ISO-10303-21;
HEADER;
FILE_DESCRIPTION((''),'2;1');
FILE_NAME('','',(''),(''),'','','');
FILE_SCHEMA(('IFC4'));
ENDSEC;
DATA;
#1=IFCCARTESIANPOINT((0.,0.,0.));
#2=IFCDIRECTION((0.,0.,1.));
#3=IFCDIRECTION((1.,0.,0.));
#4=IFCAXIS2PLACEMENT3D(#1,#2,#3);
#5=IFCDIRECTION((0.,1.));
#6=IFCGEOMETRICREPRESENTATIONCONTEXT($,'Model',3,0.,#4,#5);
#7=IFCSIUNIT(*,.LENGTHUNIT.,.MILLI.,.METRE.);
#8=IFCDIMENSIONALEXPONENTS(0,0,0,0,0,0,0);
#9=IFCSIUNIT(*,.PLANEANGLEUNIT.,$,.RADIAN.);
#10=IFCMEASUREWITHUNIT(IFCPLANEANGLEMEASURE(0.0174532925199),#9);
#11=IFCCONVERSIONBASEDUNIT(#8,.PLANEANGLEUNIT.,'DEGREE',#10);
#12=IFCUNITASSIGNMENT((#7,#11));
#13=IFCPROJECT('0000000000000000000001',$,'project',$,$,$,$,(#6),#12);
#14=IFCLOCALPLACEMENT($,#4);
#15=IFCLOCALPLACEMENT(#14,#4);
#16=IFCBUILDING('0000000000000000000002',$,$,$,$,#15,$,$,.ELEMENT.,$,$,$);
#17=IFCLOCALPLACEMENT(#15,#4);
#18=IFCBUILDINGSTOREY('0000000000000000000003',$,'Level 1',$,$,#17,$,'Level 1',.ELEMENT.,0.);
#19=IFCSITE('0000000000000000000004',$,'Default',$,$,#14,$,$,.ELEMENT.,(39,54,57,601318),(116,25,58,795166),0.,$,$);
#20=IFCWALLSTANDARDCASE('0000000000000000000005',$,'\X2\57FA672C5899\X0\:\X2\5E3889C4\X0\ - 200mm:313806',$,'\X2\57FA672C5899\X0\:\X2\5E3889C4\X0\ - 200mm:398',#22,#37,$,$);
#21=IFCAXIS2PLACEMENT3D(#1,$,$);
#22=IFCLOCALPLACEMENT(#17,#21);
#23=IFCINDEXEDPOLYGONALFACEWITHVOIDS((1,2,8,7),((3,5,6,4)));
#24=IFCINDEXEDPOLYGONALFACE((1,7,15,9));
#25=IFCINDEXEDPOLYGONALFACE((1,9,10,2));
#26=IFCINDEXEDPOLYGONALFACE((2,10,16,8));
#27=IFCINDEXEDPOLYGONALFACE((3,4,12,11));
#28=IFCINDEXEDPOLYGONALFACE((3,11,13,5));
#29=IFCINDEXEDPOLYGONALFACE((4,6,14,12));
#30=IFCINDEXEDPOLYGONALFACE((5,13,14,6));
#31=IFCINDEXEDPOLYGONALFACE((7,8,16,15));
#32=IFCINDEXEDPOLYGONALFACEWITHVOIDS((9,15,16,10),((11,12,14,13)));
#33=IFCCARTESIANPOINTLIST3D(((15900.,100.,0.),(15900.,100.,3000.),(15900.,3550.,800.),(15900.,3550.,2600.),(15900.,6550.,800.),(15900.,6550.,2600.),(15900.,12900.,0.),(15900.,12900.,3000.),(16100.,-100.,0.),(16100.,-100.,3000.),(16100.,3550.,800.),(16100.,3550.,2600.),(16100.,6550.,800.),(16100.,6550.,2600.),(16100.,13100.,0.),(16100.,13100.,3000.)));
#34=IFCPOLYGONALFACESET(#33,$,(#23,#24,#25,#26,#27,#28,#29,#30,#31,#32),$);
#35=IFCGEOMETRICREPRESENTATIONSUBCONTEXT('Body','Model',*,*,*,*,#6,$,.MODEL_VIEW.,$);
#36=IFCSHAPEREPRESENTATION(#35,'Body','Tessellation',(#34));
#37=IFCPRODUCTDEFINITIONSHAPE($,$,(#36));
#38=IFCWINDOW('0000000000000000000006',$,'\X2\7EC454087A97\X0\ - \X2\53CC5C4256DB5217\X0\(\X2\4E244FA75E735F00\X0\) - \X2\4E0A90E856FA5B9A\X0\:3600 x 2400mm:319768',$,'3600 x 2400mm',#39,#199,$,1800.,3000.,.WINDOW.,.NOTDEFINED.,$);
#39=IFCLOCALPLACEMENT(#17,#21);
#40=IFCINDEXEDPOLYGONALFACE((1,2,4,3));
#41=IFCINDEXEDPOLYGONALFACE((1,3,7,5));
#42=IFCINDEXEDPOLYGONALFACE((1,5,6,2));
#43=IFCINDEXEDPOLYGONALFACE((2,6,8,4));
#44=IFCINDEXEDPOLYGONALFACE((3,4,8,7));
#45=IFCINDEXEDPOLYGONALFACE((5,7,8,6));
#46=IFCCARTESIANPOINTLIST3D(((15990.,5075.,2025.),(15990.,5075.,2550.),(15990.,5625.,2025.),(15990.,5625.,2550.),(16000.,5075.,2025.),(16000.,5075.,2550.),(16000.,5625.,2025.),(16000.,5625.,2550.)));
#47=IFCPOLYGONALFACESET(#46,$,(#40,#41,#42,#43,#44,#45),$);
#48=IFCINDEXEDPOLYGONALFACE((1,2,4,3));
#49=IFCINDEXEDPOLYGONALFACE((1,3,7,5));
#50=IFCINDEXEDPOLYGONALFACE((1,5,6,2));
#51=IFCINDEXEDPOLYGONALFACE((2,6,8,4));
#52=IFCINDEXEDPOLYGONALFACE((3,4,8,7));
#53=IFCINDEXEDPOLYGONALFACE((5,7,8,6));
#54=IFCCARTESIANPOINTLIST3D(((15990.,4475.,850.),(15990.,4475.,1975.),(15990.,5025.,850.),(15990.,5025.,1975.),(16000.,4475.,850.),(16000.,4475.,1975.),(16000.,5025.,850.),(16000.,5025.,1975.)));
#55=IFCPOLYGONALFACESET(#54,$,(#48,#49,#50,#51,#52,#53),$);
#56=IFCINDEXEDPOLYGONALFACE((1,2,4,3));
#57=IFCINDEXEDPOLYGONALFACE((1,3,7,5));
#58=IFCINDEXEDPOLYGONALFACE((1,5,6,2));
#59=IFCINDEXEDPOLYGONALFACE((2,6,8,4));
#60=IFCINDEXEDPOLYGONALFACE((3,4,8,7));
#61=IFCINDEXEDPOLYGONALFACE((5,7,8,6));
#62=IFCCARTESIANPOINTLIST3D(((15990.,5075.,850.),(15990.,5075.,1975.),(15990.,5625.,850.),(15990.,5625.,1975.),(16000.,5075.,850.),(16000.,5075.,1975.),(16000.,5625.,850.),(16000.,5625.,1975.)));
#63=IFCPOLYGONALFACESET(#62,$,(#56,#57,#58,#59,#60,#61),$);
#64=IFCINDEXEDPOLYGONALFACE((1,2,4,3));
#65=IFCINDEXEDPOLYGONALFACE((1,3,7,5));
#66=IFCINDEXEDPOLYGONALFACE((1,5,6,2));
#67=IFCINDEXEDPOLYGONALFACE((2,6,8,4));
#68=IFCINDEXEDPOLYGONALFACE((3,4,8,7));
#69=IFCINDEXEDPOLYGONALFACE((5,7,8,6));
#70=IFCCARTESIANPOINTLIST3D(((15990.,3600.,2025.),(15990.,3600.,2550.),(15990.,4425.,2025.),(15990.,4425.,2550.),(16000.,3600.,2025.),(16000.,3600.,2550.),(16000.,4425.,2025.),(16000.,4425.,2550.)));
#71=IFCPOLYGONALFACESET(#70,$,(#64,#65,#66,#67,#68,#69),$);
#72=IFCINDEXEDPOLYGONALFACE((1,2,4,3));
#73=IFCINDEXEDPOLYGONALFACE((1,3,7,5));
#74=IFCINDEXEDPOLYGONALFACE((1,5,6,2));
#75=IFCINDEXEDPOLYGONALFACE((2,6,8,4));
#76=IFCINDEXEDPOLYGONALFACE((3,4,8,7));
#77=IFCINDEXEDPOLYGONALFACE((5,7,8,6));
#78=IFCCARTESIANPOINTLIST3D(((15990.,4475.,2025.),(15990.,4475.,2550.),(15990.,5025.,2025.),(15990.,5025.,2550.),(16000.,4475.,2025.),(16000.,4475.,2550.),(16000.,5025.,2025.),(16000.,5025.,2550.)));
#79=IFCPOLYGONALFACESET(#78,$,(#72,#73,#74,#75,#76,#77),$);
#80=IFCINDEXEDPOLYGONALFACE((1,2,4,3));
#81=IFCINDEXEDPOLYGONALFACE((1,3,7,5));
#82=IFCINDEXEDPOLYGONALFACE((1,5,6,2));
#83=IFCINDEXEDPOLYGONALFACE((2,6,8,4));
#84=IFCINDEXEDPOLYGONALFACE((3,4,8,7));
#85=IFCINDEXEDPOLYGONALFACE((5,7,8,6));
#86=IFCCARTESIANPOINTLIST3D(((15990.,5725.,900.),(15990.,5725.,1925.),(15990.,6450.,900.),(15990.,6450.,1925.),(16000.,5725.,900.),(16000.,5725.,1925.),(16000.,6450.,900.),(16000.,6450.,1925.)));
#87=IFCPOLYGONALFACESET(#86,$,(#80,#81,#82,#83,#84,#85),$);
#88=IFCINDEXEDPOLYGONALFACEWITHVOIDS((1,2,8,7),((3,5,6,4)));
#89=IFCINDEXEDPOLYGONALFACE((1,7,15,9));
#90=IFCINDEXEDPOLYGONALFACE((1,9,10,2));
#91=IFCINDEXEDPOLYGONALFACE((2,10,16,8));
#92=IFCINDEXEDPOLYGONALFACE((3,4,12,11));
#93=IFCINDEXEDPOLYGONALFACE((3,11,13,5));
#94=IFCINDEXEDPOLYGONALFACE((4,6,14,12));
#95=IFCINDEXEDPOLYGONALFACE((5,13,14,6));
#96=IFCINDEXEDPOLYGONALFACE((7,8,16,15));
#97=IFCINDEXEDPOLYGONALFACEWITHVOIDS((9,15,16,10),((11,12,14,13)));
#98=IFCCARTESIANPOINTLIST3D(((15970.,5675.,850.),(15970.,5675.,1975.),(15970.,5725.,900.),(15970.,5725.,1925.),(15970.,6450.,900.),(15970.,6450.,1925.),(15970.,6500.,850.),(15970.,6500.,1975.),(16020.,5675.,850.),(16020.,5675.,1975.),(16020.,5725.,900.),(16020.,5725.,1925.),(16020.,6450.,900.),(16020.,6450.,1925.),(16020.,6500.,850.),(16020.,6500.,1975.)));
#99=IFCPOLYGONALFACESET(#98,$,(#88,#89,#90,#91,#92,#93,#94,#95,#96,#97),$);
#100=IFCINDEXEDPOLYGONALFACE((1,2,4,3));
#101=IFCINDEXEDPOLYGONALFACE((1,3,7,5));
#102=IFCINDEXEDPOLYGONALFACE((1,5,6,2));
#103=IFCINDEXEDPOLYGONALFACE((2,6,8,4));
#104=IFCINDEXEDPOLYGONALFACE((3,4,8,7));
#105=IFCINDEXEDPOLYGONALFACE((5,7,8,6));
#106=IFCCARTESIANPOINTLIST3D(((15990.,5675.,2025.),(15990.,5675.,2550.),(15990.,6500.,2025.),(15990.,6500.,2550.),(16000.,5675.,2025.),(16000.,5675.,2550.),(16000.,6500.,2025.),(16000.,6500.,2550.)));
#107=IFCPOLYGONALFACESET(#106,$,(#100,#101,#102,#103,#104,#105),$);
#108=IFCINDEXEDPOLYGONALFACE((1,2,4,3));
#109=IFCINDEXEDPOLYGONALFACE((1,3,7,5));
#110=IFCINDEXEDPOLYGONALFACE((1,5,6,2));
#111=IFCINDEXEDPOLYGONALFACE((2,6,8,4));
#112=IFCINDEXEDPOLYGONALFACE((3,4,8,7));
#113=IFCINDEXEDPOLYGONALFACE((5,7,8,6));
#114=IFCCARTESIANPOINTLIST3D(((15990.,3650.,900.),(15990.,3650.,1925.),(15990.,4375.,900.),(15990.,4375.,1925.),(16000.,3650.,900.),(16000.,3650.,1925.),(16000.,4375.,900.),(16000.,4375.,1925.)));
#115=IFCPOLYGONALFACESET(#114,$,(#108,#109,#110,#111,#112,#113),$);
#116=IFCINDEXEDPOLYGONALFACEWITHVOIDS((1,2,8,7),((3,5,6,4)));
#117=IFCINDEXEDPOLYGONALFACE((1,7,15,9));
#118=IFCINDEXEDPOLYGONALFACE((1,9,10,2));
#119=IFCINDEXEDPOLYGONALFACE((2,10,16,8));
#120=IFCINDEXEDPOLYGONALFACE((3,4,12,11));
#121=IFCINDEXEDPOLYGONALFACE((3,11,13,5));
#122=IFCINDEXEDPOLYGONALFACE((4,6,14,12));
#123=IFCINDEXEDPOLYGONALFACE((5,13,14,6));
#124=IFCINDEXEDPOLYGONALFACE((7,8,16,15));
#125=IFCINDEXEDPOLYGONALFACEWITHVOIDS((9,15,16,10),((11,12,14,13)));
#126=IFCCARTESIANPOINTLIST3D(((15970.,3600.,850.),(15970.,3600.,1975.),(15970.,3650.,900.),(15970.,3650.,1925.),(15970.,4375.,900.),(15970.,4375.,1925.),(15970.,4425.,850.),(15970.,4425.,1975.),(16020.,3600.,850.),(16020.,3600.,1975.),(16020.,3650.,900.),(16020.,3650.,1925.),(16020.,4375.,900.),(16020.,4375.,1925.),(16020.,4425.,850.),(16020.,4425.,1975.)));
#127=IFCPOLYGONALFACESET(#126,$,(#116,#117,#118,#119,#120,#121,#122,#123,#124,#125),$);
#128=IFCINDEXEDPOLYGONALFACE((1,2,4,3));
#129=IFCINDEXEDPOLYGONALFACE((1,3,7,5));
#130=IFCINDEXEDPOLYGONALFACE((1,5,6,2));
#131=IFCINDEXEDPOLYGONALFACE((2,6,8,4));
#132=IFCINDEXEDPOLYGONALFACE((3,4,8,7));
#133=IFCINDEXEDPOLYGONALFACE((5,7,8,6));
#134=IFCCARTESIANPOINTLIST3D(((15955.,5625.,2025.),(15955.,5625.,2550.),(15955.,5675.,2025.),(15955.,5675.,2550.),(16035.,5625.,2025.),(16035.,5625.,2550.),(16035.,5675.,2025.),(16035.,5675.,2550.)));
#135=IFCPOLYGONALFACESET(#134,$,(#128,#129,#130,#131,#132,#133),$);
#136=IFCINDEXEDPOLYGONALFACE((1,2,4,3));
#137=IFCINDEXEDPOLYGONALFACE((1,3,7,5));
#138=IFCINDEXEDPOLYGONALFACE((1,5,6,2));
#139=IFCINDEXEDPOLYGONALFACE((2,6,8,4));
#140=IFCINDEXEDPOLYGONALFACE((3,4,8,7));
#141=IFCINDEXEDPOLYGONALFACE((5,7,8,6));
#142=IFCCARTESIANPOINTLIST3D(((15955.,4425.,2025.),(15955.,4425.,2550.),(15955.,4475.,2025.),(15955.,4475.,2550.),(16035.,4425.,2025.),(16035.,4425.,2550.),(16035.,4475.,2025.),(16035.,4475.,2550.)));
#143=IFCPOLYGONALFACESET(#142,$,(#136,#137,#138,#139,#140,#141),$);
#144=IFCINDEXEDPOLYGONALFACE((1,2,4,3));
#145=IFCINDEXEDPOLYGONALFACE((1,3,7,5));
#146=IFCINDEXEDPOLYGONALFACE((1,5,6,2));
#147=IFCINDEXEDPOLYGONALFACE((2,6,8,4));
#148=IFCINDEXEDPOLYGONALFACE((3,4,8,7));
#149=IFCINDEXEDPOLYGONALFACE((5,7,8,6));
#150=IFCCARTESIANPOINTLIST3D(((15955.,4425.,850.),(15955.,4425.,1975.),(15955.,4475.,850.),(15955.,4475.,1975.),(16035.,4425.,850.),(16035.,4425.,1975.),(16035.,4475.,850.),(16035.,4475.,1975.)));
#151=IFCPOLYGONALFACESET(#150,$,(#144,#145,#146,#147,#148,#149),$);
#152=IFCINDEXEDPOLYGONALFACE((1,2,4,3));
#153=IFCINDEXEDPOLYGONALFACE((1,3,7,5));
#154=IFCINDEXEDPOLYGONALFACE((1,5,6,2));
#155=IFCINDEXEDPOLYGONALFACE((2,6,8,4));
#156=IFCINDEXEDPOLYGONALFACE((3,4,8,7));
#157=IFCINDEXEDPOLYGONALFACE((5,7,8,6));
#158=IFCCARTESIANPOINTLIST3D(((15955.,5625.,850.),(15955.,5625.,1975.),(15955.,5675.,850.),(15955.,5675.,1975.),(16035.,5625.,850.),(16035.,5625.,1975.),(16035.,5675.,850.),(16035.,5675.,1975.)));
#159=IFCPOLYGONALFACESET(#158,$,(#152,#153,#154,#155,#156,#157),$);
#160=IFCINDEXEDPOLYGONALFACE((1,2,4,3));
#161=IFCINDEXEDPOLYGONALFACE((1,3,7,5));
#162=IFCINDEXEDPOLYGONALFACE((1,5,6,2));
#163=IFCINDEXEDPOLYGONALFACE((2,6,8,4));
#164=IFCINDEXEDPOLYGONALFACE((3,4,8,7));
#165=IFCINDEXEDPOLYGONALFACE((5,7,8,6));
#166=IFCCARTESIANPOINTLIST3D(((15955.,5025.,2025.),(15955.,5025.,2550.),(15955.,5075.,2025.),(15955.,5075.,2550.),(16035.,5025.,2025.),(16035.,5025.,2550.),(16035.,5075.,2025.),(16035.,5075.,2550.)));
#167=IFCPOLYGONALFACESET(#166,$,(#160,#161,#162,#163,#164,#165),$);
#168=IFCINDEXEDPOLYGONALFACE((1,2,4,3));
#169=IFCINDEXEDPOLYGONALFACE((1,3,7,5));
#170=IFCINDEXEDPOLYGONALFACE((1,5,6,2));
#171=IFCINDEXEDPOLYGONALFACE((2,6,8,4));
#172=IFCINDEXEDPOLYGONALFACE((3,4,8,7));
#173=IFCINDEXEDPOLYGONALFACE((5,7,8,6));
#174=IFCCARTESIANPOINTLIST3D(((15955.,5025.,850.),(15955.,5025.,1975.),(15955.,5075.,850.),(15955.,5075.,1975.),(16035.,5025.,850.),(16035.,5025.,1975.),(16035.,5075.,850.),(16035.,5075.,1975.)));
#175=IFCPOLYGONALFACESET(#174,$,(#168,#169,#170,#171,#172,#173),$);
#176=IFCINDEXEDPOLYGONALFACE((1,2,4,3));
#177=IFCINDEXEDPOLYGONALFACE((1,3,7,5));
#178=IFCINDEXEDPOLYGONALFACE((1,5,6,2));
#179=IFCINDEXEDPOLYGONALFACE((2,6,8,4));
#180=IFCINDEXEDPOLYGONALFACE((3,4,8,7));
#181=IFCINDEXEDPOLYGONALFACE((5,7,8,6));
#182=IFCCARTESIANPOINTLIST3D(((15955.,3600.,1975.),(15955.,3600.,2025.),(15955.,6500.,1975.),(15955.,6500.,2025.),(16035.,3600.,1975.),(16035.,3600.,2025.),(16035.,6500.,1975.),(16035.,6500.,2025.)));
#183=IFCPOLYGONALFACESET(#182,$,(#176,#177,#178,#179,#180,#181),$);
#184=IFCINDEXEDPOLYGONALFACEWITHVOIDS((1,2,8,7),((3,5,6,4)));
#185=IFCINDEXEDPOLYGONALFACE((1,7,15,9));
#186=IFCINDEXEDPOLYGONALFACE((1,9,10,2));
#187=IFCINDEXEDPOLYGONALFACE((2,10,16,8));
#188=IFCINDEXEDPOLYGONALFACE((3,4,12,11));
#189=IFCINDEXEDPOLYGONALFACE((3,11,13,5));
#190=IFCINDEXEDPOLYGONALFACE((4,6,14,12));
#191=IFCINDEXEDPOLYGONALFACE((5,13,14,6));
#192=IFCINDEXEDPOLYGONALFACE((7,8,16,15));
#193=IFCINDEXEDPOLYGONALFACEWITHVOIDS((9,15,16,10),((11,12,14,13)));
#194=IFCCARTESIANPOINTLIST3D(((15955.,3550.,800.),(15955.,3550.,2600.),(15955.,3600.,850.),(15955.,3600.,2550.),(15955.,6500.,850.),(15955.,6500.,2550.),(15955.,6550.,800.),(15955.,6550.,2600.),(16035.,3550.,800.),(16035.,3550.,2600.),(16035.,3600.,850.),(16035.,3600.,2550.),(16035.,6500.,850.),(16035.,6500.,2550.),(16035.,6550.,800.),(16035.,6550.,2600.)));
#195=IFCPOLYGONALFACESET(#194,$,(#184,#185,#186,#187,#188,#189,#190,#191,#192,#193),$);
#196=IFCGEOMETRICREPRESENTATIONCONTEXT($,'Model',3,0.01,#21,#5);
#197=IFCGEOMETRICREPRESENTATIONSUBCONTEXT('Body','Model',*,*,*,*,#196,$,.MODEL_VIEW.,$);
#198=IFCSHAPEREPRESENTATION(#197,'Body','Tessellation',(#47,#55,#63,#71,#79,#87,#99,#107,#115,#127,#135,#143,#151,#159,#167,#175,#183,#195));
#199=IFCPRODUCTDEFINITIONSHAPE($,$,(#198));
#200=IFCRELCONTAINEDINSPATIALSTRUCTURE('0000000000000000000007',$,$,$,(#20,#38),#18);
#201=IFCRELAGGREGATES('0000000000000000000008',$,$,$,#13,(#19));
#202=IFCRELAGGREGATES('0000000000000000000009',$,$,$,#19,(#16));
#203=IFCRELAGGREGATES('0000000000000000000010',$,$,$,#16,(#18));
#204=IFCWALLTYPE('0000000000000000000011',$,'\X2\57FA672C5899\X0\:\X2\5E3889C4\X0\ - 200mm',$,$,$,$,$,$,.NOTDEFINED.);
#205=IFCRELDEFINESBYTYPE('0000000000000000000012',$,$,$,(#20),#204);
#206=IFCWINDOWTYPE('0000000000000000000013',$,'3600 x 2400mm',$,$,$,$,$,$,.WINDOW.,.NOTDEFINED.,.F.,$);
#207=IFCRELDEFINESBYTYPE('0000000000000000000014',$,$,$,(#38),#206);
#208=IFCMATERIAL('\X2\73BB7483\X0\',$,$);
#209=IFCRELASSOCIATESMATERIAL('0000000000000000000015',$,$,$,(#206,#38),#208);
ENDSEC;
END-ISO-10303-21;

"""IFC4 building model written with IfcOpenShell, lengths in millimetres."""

from ifc_helpers import new_model, entity, si_unit, converted_unit, direction, frame, frame_2d, origin, origin_with_axes, origin_2d_with_axis, place, context, subcontext, project, spatial, polyline, rectangle, outline, extrude, source, transform, mapped, material, type_object, type_shapes, element, fill, save


model = new_model("IFC4")

# Units and contexts
model_context_1 = context("Model", 3, precision=0.0, world=origin_with_axes(), true_north=direction((0.0, 1.0)))
model_context_2 = context("Model", 3, precision=0.01, world=origin(), true_north=direction((0.0, 1.0)))
body_context_1 = subcontext(model_context_1, "Body", "Model", "MODEL_VIEW")
body_context_2 = subcontext(model_context_2, "Body", "Model", "MODEL_VIEW")
ifc_project = project(units=[si_unit("LENGTHUNIT", "METRE", prefix="MILLI"), converted_unit("PLANEANGLEUNIT", "DEGREE", entity("IfcPlaneAngleMeasure", 0.0174532925199), si_unit("PLANEANGLEUNIT", "RADIAN"), dimensions=[0, 0, 0, 0, 0, 0, 0])], contexts=[model_context_1])

# Site, building, storey
site_placement = place(None, origin_with_axes())
site = spatial("IfcSite", under=ifc_project, at=site_placement, Name="Default", CompositionType="ELEMENT", RefLatitude=(39, 54, 57, 601318), RefLongitude=(116, 25, 58, 795166), RefElevation=0.0)
building_placement = place(site_placement, origin_with_axes())
building = spatial("IfcBuilding", under=site, at=building_placement, CompositionType="ELEMENT")
storey_placement = place(building_placement, origin_with_axes())
storey = spatial("IfcBuildingStorey", under=building, at=storey_placement, Name="Level 1", LongName="Level 1", CompositionType="ELEMENT", Elevation=0.0)

# Shared definitions
wall_type_1 = type_object("IfcWallType", Name="基本墙:常规 - 200mm", PredefinedType="NOTDEFINED")
placement_1 = place(None, origin())
placement_2 = place(placement_1, origin())
placement_3 = place(placement_2, origin())
ifc_material_1 = material(Name="玻璃")
window_type_1 = type_object("IfcWindowType", Name="3600 x 2400mm", ParameterTakesPrecedence=False, PartitioningType="NOTDEFINED", PredefinedType="WINDOW", material=ifc_material_1)
shared_shape_1 = source(origin(), body_context_2, "Body", "SweptSolid", [
    extrude(rectangle(XDim=10.0, YDim=550.0, at=origin_2d_with_axis()), frame((1200.0, 95.0, 1225.0), z_axis=(0.0, 0.0, 1.0), x_axis=(0.0, 1.0, 0.0)), (0.0, 0.0, 1.0), 525.0),
    extrude(rectangle(XDim=10.0, YDim=550.0, at=origin_2d_with_axis()), frame((1800.0, 95.0, 50.0), z_axis=(0.0, 0.0, 1.0), x_axis=(0.0, 1.0, 0.0)), (0.0, 0.0, 1.0), 1125.0),
    extrude(rectangle(XDim=10.0, YDim=550.0, at=origin_2d_with_axis()), frame((1200.0, 95.0, 50.0), z_axis=(0.0, 0.0, 1.0), x_axis=(0.0, 1.0, 0.0)), (0.0, 0.0, 1.0), 1125.0),
    extrude(rectangle(XDim=10.0, YDim=825.0, at=origin_2d_with_axis()), frame((2537.5, 95.0, 1225.0), z_axis=(0.0, 0.0, 1.0), x_axis=(0.0, 1.0, 0.0)), (0.0, 0.0, 1.0), 525.0),
    extrude(rectangle(XDim=10.0, YDim=550.0, at=origin_2d_with_axis()), frame((1800.0, 95.0, 1225.0), z_axis=(0.0, 0.0, 1.0), x_axis=(0.0, 1.0, 0.0)), (0.0, 0.0, 1.0), 525.0),
    extrude(rectangle(XDim=10.0, YDim=725.0, at=origin_2d_with_axis()), frame((462.5, 95.0, 100.0), z_axis=(0.0, 0.0, 1.0), x_axis=(0.0, 1.0, 0.0)), (0.0, 0.0, 1.0), 1025.0),
    extrude(outline(polyline([(-562.5, -412.5), (562.5, -412.5), (562.5, 412.5), (-562.5, 412.5), (-562.5, -412.5)]), holes=[polyline([(512.5, -362.5), (-512.5, -362.5), (-512.5, 362.5), (512.5, 362.5), (512.5, -362.5)])]), frame((462.5, 70.0, 612.5), z_axis=(0.0, 1.0, 0.0), x_axis=(0.0, 0.0, -1.0)), (0.0, 0.0, 1.0), 50.0),
    extrude(rectangle(XDim=10.0, YDim=825.0, at=origin_2d_with_axis()), frame((462.5, 95.0, 1225.0), z_axis=(0.0, 0.0, 1.0), x_axis=(0.0, 1.0, 0.0)), (0.0, 0.0, 1.0), 525.0),
    extrude(rectangle(XDim=10.0, YDim=725.0, at=origin_2d_with_axis()), frame((2537.5, 95.0, 100.0), z_axis=(0.0, 0.0, 1.0), x_axis=(0.0, 1.0, 0.0)), (0.0, 0.0, 1.0), 1025.0),
    extrude(outline(polyline([(-562.5, -412.5), (562.5, -412.5), (562.5, 412.5), (-562.5, 412.5), (-562.5, -412.5)]), holes=[polyline([(512.5, -362.5), (-512.5, -362.5), (-512.5, 362.5), (512.5, 362.5), (512.5, -362.5)])]), frame((2537.5, 70.0, 612.5), z_axis=(0.0, 1.0, 0.0), x_axis=(0.0, 0.0, -1.0)), (0.0, 0.0, 1.0), 50.0),
    extrude(rectangle(XDim=80.0, YDim=50.0, at=origin_2d_with_axis()), frame((900.0, 95.0, 1225.0), z_axis=(0.0, 0.0, 1.0), x_axis=(0.0, -1.0, 0.0)), (0.0, 0.0, 1.0), 525.0),
    extrude(rectangle(XDim=80.0, YDim=50.0, at=origin_2d_with_axis()), frame((2100.0, 95.0, 1225.0), z_axis=(0.0, 0.0, 1.0), x_axis=(0.0, -1.0, 0.0)), (0.0, 0.0, 1.0), 525.0),
    extrude(rectangle(XDim=80.0, YDim=50.0, at=origin_2d_with_axis()), frame((2100.0, 95.0, 50.0), z_axis=(0.0, 0.0, 1.0), x_axis=(0.0, -1.0, 0.0)), (0.0, 0.0, 1.0), 1125.0),
    extrude(rectangle(XDim=80.0, YDim=50.0, at=origin_2d_with_axis()), frame((900.0, 95.0, 50.0), z_axis=(0.0, 0.0, 1.0), x_axis=(0.0, -1.0, 0.0)), (0.0, 0.0, 1.0), 1125.0),
    extrude(rectangle(XDim=80.0, YDim=50.0, at=origin_2d_with_axis()), frame((1500.0, 95.0, 1225.0), z_axis=(0.0, 0.0, 1.0), x_axis=(0.0, -1.0, 0.0)), (0.0, 0.0, 1.0), 525.0),
    extrude(rectangle(XDim=80.0, YDim=50.0, at=origin_2d_with_axis()), frame((1500.0, 95.0, 50.0), z_axis=(0.0, 0.0, 1.0), x_axis=(0.0, -1.0, 0.0)), (0.0, 0.0, 1.0), 1125.0),
    extrude(rectangle(XDim=80.0, YDim=2900.0, at=origin_2d_with_axis()), frame((1500.0, 95.0, 1175.0), z_axis=(0.0, 0.0, 1.0), x_axis=(0.0, -1.0, 0.0)), (0.0, 0.0, 1.0), 50.0),
    extrude(outline(polyline([(-1500.0, -900.0), (1500.0, -900.0), (1500.0, 900.0), (-1500.0, 900.0), (-1500.0, -900.0)]), holes=[polyline([(1450.0, -850.0), (-1450.0, -850.0), (-1450.0, 850.0), (1450.0, 850.0), (1450.0, -850.0)])]), frame((1500.0, 55.0, 900.0), z_axis=(0.0, 1.0, 0.0), x_axis=(1.0, 0.0, 0.0)), (0.0, 0.0, 1.0), 80.0),
])
type_shapes(window_type_1, [shared_shape_1])

# Wall, opening, window
wall_1_placement = place(storey_placement, frame((16000.0, 13000.0, 0.0), z_axis=(0.0, 0.0, 1.0), x_axis=(0.0, -1.0, 0.0)))
wall_1 = element("IfcWallStandardCase", 1, at=wall_1_placement, inside=storey, type_object=wall_type_1, Name="基本墙:常规 - 200mm:313806", ObjectType="基本墙:常规 - 200mm:398", context=body_context_1, shape_type="SweptSolid", body=[
    extrude(outline(polyline([(100.0, -100.0), (12900.0, -100.0), (13100.0, 100.0), (-100.0, 100.0), (100.0, -100.0)])), origin_with_axes(), (0.0, 0.0, 1.0), 3000.0),
])
placement_4 = place(placement_3, frame((16000.0, 12900.0, 0.0), z_axis=(0.0, 0.0, 1.0), x_axis=(0.0, -1.0, 0.0)))
opening_1_placement = place(placement_4, frame((6350.0, -100.0, 800.0)))
opening_1 = element("IfcOpeningElement", 2, at=opening_1_placement, cuts=wall_1, ObjectType="Opening", PredefinedType="OPENING", context=body_context_2, shape_type="SweptSolid", body=[
    extrude(rectangle(XDim=1800.0, YDim=3000.0, at=frame_2d((900.0, 1500.0), x_axis=(1.0, 0.0))), frame((0.0, 0.0, 0.0), z_axis=(0.0, 1.0, 0.0), x_axis=(0.0, 0.0, 1.0)), (0.0, 0.0, 1.0), 200.0),
])
window_1_placement = place(opening_1_placement, origin())
window_1 = element("IfcWindow", 3, at=window_1_placement, inside=storey, type_object=window_type_1, material=ifc_material_1, Name="组合窗 - 双层四列(两侧平开) - 上部固定:3600 x 2400mm:319768", ObjectType="3600 x 2400mm", OverallHeight=1800.0, OverallWidth=3000.0, PartitioningType="NOTDEFINED", PredefinedType="WINDOW", context=body_context_2, shape_type="MappedRepresentation", body=[
    mapped(shared_shape_1, transform((0.0, 0.0, 0.0), scale=1.0)),
])
fill(opening_1, window_1)

save(model, "model.ifc")
